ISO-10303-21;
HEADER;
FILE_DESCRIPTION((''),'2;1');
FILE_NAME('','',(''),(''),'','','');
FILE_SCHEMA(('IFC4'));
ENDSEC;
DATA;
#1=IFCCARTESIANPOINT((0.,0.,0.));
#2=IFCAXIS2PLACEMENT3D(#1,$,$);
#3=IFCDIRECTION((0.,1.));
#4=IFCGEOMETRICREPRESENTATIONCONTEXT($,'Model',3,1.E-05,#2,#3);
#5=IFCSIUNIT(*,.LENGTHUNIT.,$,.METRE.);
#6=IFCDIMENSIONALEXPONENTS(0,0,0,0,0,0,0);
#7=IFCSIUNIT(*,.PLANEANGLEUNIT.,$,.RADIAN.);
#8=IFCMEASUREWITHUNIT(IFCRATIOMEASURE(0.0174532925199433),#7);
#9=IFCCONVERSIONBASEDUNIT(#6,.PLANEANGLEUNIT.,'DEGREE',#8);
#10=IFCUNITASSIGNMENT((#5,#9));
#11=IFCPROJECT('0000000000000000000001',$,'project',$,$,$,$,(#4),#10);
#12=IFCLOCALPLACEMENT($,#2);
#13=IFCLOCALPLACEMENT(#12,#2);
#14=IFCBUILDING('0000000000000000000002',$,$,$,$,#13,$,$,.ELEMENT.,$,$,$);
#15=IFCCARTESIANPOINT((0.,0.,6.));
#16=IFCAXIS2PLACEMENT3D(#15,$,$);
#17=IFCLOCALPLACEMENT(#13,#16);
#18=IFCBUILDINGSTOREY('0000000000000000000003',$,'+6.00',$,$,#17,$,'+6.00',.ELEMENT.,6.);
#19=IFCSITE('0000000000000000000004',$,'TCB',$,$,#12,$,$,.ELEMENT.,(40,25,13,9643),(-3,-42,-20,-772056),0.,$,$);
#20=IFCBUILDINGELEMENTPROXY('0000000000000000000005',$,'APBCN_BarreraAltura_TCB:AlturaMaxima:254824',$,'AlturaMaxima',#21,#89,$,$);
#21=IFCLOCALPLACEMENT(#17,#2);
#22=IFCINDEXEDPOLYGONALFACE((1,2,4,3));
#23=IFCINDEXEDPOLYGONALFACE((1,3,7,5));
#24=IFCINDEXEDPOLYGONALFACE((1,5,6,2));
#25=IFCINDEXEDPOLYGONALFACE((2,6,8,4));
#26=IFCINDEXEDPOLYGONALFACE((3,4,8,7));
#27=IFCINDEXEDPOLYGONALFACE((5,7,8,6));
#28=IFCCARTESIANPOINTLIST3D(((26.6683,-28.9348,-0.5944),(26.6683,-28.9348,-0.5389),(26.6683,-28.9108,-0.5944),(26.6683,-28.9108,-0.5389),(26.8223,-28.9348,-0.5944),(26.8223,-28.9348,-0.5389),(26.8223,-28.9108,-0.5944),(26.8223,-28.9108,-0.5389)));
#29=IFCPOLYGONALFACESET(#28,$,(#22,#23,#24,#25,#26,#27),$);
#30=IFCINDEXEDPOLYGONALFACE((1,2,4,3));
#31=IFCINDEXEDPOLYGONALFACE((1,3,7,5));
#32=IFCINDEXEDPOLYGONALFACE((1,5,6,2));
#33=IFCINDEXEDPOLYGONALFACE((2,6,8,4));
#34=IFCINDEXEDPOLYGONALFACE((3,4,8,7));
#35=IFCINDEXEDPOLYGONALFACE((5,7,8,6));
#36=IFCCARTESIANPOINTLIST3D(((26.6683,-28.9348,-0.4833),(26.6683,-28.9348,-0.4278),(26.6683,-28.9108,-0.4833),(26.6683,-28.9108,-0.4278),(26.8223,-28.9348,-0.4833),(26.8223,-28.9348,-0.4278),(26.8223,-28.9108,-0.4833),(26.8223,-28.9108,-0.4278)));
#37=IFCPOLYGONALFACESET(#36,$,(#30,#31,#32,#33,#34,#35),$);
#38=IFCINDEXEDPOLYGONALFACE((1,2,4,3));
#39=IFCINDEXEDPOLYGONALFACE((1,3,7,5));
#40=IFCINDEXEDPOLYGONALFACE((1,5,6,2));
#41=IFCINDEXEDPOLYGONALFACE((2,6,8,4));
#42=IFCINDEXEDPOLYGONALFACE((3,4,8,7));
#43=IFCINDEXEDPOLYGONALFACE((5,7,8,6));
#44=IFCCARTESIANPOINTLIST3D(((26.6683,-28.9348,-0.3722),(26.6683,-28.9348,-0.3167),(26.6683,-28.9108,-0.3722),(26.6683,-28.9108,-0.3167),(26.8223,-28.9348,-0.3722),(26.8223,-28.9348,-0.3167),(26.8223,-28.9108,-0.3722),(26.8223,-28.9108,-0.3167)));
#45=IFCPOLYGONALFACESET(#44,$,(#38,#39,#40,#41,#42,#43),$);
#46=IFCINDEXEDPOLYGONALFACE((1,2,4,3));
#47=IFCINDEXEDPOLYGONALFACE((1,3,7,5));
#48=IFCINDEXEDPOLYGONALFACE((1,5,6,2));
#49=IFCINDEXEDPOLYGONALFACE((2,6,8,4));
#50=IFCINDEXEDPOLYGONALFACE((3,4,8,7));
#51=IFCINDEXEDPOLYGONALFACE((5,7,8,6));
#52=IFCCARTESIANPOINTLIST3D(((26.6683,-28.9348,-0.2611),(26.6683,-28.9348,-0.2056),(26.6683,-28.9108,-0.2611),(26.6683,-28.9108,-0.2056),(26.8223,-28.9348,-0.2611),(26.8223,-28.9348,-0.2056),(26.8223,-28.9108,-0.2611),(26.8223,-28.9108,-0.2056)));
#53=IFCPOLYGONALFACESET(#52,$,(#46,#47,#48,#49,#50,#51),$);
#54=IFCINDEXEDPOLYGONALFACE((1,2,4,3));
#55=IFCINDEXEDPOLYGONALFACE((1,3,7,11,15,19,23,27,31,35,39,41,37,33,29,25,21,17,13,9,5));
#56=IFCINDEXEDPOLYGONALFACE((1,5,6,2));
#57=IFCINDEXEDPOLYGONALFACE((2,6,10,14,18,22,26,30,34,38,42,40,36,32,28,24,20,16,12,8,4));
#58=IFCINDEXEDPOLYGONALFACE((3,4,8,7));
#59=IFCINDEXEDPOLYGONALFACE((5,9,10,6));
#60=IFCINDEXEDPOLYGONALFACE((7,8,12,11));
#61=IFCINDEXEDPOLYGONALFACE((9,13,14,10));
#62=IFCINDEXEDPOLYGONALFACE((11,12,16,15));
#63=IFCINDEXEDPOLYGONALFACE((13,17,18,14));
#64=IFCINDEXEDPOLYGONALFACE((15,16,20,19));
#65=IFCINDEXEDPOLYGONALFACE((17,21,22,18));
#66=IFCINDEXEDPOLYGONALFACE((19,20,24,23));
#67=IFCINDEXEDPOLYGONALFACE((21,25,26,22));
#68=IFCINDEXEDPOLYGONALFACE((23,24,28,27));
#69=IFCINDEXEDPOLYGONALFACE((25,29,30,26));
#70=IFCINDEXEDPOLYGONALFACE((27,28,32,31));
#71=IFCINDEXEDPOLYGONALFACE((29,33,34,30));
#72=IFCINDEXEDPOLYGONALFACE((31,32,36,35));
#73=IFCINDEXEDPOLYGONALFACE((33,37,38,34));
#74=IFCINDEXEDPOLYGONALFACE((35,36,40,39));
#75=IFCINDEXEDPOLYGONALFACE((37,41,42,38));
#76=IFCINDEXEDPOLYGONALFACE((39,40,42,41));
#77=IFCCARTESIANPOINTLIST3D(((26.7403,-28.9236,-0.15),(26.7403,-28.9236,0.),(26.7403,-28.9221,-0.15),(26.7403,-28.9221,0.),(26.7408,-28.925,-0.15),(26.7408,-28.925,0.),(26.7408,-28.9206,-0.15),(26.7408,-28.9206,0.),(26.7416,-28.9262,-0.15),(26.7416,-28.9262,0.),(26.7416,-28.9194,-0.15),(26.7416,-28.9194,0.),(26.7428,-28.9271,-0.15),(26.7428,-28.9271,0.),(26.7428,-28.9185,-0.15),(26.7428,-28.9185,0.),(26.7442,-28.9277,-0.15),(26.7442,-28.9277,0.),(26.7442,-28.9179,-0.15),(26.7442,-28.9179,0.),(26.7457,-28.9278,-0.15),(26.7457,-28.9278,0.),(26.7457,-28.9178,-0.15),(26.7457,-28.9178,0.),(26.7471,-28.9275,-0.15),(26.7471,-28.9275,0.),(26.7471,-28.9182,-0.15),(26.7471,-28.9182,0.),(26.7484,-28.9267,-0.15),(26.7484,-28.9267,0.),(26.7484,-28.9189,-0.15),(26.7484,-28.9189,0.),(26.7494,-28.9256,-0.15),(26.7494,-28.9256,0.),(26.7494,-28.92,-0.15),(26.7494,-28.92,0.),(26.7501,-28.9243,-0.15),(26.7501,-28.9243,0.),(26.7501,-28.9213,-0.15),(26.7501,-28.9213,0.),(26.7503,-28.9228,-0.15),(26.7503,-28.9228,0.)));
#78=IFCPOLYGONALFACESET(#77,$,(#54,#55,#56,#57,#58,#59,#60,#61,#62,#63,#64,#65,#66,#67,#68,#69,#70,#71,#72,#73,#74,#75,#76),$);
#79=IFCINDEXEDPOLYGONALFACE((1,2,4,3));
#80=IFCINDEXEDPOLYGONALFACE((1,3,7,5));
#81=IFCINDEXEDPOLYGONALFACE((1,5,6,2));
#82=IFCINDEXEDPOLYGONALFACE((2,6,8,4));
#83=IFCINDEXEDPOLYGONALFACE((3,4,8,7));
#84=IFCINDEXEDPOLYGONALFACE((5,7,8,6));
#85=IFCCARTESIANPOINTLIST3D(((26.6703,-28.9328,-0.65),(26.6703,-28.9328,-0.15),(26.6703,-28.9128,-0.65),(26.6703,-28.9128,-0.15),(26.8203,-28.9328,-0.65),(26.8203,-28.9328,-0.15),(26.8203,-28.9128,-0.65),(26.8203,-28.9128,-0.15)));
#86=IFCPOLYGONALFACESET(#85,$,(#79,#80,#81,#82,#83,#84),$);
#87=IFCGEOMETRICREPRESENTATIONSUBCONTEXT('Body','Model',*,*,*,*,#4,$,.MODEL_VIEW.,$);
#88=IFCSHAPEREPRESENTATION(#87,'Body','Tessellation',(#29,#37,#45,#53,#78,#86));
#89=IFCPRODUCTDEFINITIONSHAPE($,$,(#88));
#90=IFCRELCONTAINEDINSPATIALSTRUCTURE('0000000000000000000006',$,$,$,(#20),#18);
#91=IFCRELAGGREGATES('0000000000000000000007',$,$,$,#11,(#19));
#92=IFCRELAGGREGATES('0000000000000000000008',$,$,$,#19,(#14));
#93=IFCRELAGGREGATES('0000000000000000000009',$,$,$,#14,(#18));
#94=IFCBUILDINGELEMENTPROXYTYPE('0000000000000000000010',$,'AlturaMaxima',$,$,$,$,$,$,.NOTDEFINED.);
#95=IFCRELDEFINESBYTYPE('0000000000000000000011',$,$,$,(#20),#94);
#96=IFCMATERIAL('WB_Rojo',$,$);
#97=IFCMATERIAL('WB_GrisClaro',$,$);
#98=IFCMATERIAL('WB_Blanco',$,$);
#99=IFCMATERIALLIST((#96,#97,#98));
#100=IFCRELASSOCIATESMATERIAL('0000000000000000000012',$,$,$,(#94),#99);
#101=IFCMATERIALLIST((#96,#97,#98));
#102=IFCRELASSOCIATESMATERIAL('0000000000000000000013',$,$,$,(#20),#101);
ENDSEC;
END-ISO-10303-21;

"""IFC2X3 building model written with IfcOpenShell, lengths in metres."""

from ifc_helpers import new_model, entity, si_unit, converted_unit, direction, frame, frame_2d, origin, origin_2d_with_axis, place, context, subcontext, project, spatial, rectangle, circle, extrude, source, transform, mapped, material, material_list, type_object, type_shapes, element, save


model = new_model("IFC2X3")

# Units and contexts
model_context = context("Model", 3, precision=1e-05, world=origin(), true_north=direction((0.0, 1.0)))
body_context = subcontext(model_context, "Body", "Model", "MODEL_VIEW")
ifc_project = project(units=[si_unit("LENGTHUNIT", "METRE"), converted_unit("PLANEANGLEUNIT", "DEGREE", entity("IfcRatioMeasure", 0.0174532925199433), si_unit("PLANEANGLEUNIT", "RADIAN"), dimensions=[0, 0, 0, 0, 0, 0, 0])], contexts=[model_context])

# Site, building, storey
site_placement = place(None, origin())
site = spatial("IfcSite", under=ifc_project, at=site_placement, Name="TCB", CompositionType="ELEMENT", RefLatitude=(40, 25, 13, 9643), RefLongitude=(-3, -42, -20, -772056), RefElevation=0.0)
building_placement = place(site_placement, origin())
building = spatial("IfcBuilding", under=site, at=building_placement, CompositionType="ELEMENT")
storey_placement = place(building_placement, frame((0.0, 0.0, 6.0)))
storey = spatial("IfcBuildingStorey", under=building, at=storey_placement, Name="+6.00", LongName="+6.00", CompositionType="ELEMENT", Elevation=6.0)

# Building element proxy
ifc_material_1 = material(Name="WB_Rojo")
ifc_material_2 = material(Name="WB_GrisClaro")
ifc_material_3 = material(Name="WB_Blanco")
ifc_material_list_1 = material_list([ifc_material_1, ifc_material_2, ifc_material_3])
building_element_proxy_type = type_object("IfcBuildingElementProxyType", Name="AlturaMaxima", PredefinedType="NOTDEFINED", material=ifc_material_list_1)
shared_shape = source(origin(), body_context, "Body", "SweptSolid", [
    extrude(rectangle(XDim=0.154, YDim=0.024, at=frame_2d((0.0, 0.0), x_axis=(1.0, 0.0))), frame((0.0, 0.0, -0.5944), z_axis=(0.0, 0.0, 1.0), x_axis=(-1.0, 0.0, 0.0)), (0.0, 0.0, 1.0), 0.0556),
    extrude(rectangle(XDim=0.154, YDim=0.024, at=frame_2d((0.0, 0.0), x_axis=(1.0, 0.0))), frame((0.0, 0.0, -0.4833), z_axis=(0.0, 0.0, 1.0), x_axis=(-1.0, 0.0, 0.0)), (0.0, 0.0, 1.0), 0.0556),
    extrude(rectangle(XDim=0.154, YDim=0.024, at=frame_2d((0.0, 0.0), x_axis=(1.0, 0.0))), frame((0.0, 0.0, -0.3722), z_axis=(0.0, 0.0, 1.0), x_axis=(-1.0, 0.0, 0.0)), (0.0, 0.0, 1.0), 0.0556),
    extrude(rectangle(XDim=0.154, YDim=0.024, at=frame_2d((0.0, 0.0), x_axis=(1.0, 0.0))), frame((0.0, 0.0, -0.2611), z_axis=(0.0, 0.0, 1.0), x_axis=(-1.0, 0.0, 0.0)), (0.0, 0.0, 1.0), 0.0556),
    extrude(circle(Radius=0.005, at=frame_2d((0.0, 0.0), x_axis=(1.0, 0.0))), frame((0.0, 0.0, -0.15)), (0.0, 0.0, 1.0), 0.15),
    extrude(rectangle(XDim=0.02, YDim=0.15, at=origin_2d_with_axis()), frame((0.0, 0.0, -0.65), z_axis=(0.0, 0.0, 1.0), x_axis=(0.0, 1.0, 0.0)), (0.0, 0.0, 1.0), 0.5),
])
type_shapes(building_element_proxy_type, [shared_shape])
ifc_material_list_2 = material_list([ifc_material_1, ifc_material_2, ifc_material_3])
proxy_1_placement = place(storey_placement, frame((26.7453, -28.9228, 0.0)))
element("IfcBuildingElementProxy", 1, at=proxy_1_placement, inside=storey, type_object=building_element_proxy_type, material=ifc_material_list_2, Name="APBCN_BarreraAltura_TCB:AlturaMaxima:254824", ObjectType="AlturaMaxima", context=body_context, shape_type="MappedRepresentation", body=[
    mapped(shared_shape, transform((0.0, 0.0, 0.0), scale=1.0)),
])

save(model, "model.ifc")
